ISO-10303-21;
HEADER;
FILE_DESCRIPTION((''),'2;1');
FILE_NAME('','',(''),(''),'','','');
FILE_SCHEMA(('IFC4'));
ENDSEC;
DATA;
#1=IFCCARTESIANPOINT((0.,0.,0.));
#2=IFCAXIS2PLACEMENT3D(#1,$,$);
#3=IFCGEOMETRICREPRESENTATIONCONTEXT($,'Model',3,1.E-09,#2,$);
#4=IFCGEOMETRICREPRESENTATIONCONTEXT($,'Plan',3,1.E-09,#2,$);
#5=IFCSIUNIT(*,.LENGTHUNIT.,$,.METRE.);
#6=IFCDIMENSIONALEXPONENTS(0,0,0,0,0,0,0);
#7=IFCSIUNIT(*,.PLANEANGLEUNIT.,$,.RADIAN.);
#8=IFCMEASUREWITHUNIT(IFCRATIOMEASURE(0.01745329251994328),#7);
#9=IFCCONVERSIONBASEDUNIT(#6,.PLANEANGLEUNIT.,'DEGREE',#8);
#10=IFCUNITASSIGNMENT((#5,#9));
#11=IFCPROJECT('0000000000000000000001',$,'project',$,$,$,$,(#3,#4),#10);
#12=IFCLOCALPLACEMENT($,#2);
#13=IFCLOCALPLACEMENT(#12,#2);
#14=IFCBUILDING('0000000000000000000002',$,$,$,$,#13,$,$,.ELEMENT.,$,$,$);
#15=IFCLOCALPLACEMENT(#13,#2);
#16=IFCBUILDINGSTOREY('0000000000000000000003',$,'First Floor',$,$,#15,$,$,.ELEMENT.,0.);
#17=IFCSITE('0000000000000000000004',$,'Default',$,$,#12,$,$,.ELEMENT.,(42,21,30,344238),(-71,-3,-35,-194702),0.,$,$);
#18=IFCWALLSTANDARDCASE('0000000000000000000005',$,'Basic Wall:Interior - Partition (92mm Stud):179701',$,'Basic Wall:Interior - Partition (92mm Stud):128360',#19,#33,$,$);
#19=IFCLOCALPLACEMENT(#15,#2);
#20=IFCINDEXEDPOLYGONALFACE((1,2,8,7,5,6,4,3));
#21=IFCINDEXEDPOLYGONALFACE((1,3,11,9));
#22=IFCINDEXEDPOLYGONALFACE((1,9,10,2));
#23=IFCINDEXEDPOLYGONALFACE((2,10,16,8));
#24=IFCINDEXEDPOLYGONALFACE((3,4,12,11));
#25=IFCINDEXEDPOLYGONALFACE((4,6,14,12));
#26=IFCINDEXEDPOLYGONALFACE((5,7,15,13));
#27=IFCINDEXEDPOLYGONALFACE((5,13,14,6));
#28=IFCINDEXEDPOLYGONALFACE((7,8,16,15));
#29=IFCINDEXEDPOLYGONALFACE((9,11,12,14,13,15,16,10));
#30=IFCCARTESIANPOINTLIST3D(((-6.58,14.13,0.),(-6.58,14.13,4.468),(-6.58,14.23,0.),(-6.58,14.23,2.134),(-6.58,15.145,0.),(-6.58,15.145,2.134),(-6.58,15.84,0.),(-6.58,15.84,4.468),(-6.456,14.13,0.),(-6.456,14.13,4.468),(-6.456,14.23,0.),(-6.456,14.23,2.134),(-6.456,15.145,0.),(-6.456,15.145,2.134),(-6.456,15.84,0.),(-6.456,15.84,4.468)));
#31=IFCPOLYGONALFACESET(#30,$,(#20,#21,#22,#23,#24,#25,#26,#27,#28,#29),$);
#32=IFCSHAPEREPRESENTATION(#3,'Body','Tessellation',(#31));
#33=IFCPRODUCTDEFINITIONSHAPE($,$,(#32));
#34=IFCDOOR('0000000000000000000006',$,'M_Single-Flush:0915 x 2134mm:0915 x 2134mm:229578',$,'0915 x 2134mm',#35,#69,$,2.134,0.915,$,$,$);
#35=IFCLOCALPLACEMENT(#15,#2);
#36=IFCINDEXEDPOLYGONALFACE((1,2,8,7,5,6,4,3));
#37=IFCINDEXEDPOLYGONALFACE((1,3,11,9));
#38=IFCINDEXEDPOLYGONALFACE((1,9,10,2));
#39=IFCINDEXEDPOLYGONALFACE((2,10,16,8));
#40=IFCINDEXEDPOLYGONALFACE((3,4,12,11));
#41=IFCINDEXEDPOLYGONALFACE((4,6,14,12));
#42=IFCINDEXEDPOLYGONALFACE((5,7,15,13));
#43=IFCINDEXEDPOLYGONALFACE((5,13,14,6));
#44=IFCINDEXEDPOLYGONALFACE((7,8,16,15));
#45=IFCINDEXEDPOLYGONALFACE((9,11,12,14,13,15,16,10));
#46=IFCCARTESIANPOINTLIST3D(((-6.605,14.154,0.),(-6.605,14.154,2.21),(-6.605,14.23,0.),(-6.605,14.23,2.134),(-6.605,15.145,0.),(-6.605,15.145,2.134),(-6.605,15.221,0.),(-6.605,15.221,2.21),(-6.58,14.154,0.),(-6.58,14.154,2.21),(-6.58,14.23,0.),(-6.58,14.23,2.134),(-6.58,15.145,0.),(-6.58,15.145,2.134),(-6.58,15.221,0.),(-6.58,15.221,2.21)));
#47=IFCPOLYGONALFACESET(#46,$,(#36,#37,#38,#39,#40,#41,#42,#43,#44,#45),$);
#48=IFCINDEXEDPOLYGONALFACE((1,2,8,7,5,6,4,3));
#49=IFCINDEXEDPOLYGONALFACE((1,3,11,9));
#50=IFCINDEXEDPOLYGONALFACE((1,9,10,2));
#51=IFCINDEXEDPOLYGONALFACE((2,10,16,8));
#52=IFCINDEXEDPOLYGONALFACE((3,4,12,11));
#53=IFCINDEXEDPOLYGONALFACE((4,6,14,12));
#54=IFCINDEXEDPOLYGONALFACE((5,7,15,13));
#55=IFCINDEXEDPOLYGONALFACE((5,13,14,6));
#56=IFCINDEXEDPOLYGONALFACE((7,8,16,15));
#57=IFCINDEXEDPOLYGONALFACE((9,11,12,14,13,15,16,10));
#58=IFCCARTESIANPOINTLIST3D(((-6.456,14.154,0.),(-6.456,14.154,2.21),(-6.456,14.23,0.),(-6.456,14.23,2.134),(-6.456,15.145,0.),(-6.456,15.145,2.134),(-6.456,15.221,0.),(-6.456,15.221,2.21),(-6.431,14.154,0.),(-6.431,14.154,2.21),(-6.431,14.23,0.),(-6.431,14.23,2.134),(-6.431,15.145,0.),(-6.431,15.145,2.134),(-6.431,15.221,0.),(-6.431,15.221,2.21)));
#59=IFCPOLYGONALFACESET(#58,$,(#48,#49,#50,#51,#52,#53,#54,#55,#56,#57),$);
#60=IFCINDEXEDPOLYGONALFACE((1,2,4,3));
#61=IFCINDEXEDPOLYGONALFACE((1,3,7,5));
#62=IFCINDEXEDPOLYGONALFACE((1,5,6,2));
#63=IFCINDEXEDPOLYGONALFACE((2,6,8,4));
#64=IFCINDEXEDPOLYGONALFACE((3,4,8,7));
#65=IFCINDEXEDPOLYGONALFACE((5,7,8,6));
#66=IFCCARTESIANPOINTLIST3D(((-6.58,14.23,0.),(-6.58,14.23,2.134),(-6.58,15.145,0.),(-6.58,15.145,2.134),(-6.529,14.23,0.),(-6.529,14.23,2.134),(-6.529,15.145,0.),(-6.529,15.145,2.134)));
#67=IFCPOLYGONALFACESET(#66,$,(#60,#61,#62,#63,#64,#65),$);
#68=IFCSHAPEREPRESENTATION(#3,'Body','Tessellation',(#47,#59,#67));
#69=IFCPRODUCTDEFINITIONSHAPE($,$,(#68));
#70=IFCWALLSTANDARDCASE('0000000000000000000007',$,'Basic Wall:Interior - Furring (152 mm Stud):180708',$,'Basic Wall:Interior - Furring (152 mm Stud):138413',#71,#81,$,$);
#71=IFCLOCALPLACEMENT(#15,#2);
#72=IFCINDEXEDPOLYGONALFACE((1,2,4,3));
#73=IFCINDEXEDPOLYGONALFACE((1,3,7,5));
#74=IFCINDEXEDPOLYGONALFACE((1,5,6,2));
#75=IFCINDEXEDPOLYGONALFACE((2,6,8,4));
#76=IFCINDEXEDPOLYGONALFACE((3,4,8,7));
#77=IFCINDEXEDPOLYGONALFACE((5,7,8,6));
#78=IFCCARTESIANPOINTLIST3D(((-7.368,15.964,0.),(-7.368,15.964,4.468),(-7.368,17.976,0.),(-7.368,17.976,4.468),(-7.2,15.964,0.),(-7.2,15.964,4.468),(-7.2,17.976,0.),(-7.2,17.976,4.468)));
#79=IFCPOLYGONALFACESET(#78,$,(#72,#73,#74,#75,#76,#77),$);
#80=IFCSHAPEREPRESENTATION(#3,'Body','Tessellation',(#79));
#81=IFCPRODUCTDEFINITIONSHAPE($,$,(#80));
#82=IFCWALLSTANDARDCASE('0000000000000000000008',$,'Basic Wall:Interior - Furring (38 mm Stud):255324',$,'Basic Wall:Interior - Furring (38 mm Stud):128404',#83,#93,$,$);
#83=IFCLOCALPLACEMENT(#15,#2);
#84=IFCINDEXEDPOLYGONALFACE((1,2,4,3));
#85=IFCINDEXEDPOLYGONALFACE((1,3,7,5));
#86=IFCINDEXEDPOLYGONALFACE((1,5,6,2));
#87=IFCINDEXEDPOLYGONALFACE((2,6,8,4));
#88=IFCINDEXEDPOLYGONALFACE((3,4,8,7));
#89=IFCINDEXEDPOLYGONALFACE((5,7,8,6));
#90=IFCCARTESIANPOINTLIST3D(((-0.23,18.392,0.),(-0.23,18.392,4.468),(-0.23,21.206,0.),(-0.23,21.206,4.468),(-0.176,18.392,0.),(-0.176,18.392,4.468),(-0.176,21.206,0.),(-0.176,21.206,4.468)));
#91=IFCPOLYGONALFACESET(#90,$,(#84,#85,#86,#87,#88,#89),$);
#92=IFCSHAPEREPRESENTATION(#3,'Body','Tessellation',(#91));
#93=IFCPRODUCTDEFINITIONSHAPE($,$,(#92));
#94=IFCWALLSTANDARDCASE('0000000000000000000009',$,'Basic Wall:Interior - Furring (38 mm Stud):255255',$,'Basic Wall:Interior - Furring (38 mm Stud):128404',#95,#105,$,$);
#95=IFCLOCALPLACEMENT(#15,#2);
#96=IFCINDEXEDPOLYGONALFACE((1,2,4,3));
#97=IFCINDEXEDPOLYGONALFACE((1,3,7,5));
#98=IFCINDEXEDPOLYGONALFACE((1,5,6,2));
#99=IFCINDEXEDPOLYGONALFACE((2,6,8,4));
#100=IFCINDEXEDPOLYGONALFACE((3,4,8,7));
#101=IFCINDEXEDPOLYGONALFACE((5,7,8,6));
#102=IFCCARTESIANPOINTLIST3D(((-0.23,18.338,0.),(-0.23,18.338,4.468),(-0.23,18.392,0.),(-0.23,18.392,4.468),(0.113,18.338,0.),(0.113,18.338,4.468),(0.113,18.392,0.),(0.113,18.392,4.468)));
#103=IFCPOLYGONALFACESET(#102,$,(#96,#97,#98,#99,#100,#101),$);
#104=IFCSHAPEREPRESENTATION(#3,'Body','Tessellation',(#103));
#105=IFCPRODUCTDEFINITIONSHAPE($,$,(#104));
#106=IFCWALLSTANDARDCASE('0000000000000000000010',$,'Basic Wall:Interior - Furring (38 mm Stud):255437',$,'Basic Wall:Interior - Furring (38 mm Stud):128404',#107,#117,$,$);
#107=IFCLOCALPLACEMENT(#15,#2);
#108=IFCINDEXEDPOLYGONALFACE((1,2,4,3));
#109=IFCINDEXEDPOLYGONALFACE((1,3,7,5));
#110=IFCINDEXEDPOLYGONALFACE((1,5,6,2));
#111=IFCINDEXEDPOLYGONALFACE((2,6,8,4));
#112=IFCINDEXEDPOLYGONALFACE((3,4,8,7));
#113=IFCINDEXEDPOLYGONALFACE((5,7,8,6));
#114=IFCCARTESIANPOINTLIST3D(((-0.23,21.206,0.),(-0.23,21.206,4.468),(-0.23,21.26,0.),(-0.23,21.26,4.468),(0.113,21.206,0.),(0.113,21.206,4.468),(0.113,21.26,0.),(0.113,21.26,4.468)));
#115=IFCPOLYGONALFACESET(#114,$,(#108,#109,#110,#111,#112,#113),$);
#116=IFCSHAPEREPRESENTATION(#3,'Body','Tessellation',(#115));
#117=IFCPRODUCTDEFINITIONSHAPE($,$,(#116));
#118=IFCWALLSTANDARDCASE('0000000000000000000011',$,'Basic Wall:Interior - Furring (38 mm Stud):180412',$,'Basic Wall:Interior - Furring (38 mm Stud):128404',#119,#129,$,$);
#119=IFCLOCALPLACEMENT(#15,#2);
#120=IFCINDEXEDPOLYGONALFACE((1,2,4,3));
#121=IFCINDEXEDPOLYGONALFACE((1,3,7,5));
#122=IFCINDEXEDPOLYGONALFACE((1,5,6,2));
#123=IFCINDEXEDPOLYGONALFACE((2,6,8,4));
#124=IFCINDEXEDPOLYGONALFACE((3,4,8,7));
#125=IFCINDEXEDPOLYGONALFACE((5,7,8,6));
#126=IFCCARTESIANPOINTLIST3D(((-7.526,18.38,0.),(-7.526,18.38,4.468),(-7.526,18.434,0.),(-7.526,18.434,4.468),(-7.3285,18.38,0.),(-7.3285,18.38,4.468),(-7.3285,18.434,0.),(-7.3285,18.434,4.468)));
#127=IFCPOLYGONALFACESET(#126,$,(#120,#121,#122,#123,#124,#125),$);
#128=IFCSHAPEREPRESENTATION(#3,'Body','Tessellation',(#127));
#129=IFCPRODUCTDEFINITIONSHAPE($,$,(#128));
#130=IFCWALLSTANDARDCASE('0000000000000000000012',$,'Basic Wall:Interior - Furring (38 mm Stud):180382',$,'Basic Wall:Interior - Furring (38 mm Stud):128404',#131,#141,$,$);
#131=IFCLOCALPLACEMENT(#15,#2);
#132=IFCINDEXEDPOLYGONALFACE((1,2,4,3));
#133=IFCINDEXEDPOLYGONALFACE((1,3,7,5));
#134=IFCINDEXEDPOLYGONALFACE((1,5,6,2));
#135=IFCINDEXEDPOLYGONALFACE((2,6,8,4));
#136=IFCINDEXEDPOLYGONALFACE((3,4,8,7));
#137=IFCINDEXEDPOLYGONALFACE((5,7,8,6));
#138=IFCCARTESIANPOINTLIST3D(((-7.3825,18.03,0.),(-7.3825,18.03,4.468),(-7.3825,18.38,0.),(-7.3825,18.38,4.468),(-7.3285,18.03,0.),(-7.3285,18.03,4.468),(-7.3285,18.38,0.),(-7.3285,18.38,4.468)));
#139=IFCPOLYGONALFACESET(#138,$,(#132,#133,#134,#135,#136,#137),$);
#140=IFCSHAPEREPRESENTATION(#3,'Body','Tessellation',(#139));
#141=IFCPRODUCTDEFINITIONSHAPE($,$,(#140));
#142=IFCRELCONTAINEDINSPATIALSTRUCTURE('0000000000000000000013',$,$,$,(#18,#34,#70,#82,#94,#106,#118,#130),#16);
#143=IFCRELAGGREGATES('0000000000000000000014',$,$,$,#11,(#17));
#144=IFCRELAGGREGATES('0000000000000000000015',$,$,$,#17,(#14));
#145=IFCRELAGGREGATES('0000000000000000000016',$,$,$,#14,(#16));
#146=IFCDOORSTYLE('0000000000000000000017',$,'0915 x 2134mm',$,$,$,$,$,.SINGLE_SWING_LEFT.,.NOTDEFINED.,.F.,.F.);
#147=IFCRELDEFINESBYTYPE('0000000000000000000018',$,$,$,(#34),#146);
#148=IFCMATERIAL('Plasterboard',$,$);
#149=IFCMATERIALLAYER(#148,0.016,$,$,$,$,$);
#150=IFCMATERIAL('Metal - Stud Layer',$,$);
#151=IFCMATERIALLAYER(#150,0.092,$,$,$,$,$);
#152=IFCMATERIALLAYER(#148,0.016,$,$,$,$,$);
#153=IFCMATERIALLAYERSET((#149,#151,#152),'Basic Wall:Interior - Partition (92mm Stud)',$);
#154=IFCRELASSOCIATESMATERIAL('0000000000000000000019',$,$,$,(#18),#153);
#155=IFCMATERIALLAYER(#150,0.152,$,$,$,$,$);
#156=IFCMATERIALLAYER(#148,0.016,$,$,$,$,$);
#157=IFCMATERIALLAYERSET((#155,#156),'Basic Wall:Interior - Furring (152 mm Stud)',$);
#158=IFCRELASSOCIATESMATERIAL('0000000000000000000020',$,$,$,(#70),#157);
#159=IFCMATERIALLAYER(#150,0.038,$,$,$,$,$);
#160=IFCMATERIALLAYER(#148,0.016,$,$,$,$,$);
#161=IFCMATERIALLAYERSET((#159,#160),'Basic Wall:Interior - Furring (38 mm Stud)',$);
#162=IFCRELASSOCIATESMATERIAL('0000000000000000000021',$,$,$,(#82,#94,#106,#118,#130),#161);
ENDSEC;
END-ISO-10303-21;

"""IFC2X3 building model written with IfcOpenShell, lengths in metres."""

from ifc_helpers import new_model, entity, si_unit, converted_unit, frame, frame_2d, origin, origin_2d_with_axis, place, context, project, spatial, polyline, rectangle, outline, extrude, source, transform, mapped, material, layer, layer_set, layer_usage, type_object, type_shapes, element, fill, save


model = new_model("IFC2X3")

# Units and contexts
model_context = context("Model", 3, precision=1e-09, world=origin())
plan_context = context("Plan", 3, precision=1e-09, world=origin())
ifc_project = project(units=[si_unit("LENGTHUNIT", "METRE"), converted_unit("PLANEANGLEUNIT", "DEGREE", entity("IfcRatioMeasure", 0.01745329251994328), si_unit("PLANEANGLEUNIT", "RADIAN"), dimensions=[0, 0, 0, 0, 0, 0, 0])], contexts=[model_context, plan_context])

# Site, building, storey
site_placement = place(None, origin())
site = spatial("IfcSite", under=ifc_project, at=site_placement, Name="Default", CompositionType="ELEMENT", RefLatitude=(42, 21, 30, 344238), RefLongitude=(-71, -3, -35, -194702), RefElevation=0.0)
building_placement = place(site_placement, origin())
building = spatial("IfcBuilding", under=site, at=building_placement, CompositionType="ELEMENT")
storey_placement = place(building_placement, origin())
storey = spatial("IfcBuildingStorey", under=building, at=storey_placement, Name="First Floor", CompositionType="ELEMENT", Elevation=0.0)

# Shared definitions
ifc_material_1 = material(Name="Plasterboard")
ifc_layer_1 = layer(ifc_material_1, 0.016)
ifc_material_2 = material(Name="Metal - Stud Layer")
ifc_layer_2 = layer(ifc_material_2, 0.092)
ifc_layer_3 = layer(ifc_material_1, 0.016)
ifc_layer_set_1 = layer_set([ifc_layer_1, ifc_layer_2, ifc_layer_3], Name="Basic Wall:Interior - Partition (92mm Stud)")
ifc_layer_usage_1 = layer_usage(ifc_layer_set_1, "AXIS2", "NEGATIVE", 0.062)

# Shared definitions
door_style_1 = type_object("IfcDoorStyle", Name="0915 x 2134mm", ConstructionType="NOTDEFINED", OperationType="SINGLE_SWING_LEFT", ParameterTakesPrecedence=False, Sizeable=False)
shared_shape_1 = source(origin(), model_context, "Body", "SweptSolid", [
    extrude(outline(polyline([(-0.5335, -1.124), (0.5335, -1.124), (0.5335, 1.086), (0.4575, 1.086), (0.4575, -1.048), (-0.4575, -1.048), (-0.4575, 1.086), (-0.5335, 1.086), (-0.5335, -1.124)])), frame((0.4575, 0.149, 1.086), z_axis=(0.0, -1.0, 0.0), x_axis=(-1.0, 0.0, 0.0)), (0.0, 0.0, 1.0), 0.025),
    extrude(outline(polyline([(-1.124, -0.5335), (1.086, -0.5335), (1.086, -0.4575), (-1.048, -0.4575), (-1.048, 0.4575), (1.086, 0.4575), (1.086, 0.5335), (-1.124, 0.5335), (-1.124, -0.5335)])), frame((0.4575, 0.0, 1.086), z_axis=(0.0, -1.0, 0.0), x_axis=(0.0, 0.0, -1.0)), (0.0, 0.0, 1.0), 0.025),
    extrude(rectangle(XDim=0.915, YDim=0.051, at=origin_2d_with_axis()), frame((0.4575, 0.0985, 0.0)), (0.0, 0.0, 1.0), 2.134),
])
type_shapes(door_style_1, [shared_shape_1])

# Wall, opening, door
wall_1_placement = place(storey_placement, frame((-6.518, 14.13, 0.0), z_axis=(0.0, 0.0, 1.0), x_axis=(0.0, 1.0, 0.0)))
wall_1 = element("IfcWallStandardCase", 1, at=wall_1_placement, inside=storey, material=ifc_layer_usage_1, Name="Basic Wall:Interior - Partition (92mm Stud):179701", ObjectType="Basic Wall:Interior - Partition (92mm Stud):128360", context=model_context, shape_type="SweptSolid", body=[
    extrude(rectangle(XDim=1.71, YDim=0.124, at=frame_2d((0.855, 0.0), x_axis=(-1.0, 0.0))), origin(), (0.0, 0.0, 1.0), 4.468),
])
opening_1_placement = place(wall_1_placement, frame((0.1, -0.062, 0.0)))
opening_1 = element("IfcOpeningElement", 2, at=opening_1_placement, cuts=wall_1, ObjectType="Opening", context=model_context, shape_type="SweptSolid", body=[
    extrude(rectangle(XDim=0.915, YDim=2.134, at=frame_2d((1.067, 0.4575), x_axis=(0.0, -1.0))), frame((0.0, 0.0, 0.0), z_axis=(0.0, 1.0, 0.0), x_axis=(0.0, 0.0, 1.0)), (0.0, 0.0, 1.0), 0.124),
])
door_1_placement = place(opening_1_placement, origin())
door_1 = element("IfcDoor", 3, at=door_1_placement, inside=storey, type_object=door_style_1, Name="M_Single-Flush:0915 x 2134mm:0915 x 2134mm:229578", ObjectType="0915 x 2134mm", OverallHeight=2.134, OverallWidth=0.915, context=model_context, shape_type="MappedRepresentation", body=[
    mapped(shared_shape_1, transform((0.0, 0.0, 0.0), scale=1.0)),
])
fill(opening_1, door_1)

# Walls
ifc_layer_4 = layer(ifc_material_2, 0.152)
ifc_layer_5 = layer(ifc_material_1, 0.016)
ifc_layer_set_2 = layer_set([ifc_layer_4, ifc_layer_5], Name="Basic Wall:Interior - Furring (152 mm Stud)")
ifc_layer_usage_2 = layer_usage(ifc_layer_set_2, "AXIS2", "POSITIVE", -0.084)
wall_2_placement = place(storey_placement, frame((-7.284, 17.976, 0.0), z_axis=(0.0, 0.0, 1.0), x_axis=(0.0, -1.0, 0.0)))
element("IfcWallStandardCase", 4, at=wall_2_placement, inside=storey, material=ifc_layer_usage_2, Name="Basic Wall:Interior - Furring (152 mm Stud):180708", ObjectType="Basic Wall:Interior - Furring (152 mm Stud):138413", context=model_context, shape_type="SweptSolid", body=[
    extrude(rectangle(XDim=2.012, YDim=0.168, at=frame_2d((1.006, 0.0), x_axis=(-1.0, 0.0))), origin(), (0.0, 0.0, 1.0), 4.468),
])
ifc_layer_6 = layer(ifc_material_2, 0.038)
ifc_layer_7 = layer(ifc_material_1, 0.016)
ifc_layer_set_3 = layer_set([ifc_layer_6, ifc_layer_7], Name="Basic Wall:Interior - Furring (38 mm Stud)")
ifc_layer_usage_3 = layer_usage(ifc_layer_set_3, "AXIS2", "POSITIVE", -0.027)
wall_3_placement = place(storey_placement, frame((-0.203, 18.392, 0.0), z_axis=(0.0, 0.0, 1.0), x_axis=(0.0, 1.0, 0.0)))
element("IfcWallStandardCase", 5, at=wall_3_placement, inside=storey, material=ifc_layer_usage_3, Name="Basic Wall:Interior - Furring (38 mm Stud):255324", ObjectType="Basic Wall:Interior - Furring (38 mm Stud):128404", context=model_context, shape_type="SweptSolid", body=[
    extrude(rectangle(XDim=2.814, YDim=0.054, at=frame_2d((1.407, 0.0), x_axis=(-1.0, 0.0))), origin(), (0.0, 0.0, 1.0), 4.468),
])
wall_4_placement = place(storey_placement, frame((0.113, 18.365, 0.0), z_axis=(0.0, 0.0, 1.0), x_axis=(-1.0, 0.0, 0.0)))
element("IfcWallStandardCase", 6, at=wall_4_placement, inside=storey, material=ifc_layer_usage_3, Name="Basic Wall:Interior - Furring (38 mm Stud):255255", ObjectType="Basic Wall:Interior - Furring (38 mm Stud):128404", context=model_context, shape_type="SweptSolid", body=[
    extrude(rectangle(XDim=0.343, YDim=0.054, at=frame_2d((0.1715, 0.0), x_axis=(-1.0, 0.0))), origin(), (0.0, 0.0, 1.0), 4.468),
])
wall_5_placement = place(storey_placement, frame((-0.23, 21.233, 0.0)))
element("IfcWallStandardCase", 7, at=wall_5_placement, inside=storey, material=ifc_layer_usage_3, Name="Basic Wall:Interior - Furring (38 mm Stud):255437", ObjectType="Basic Wall:Interior - Furring (38 mm Stud):128404", context=model_context, shape_type="SweptSolid", body=[
    extrude(rectangle(XDim=0.343, YDim=0.054, at=frame_2d((0.1715, 0.0), x_axis=(-1.0, 0.0))), origin(), (0.0, 0.0, 1.0), 4.468),
])
wall_6_placement = place(storey_placement, frame((-7.3285, 18.407, 0.0), z_axis=(0.0, 0.0, 1.0), x_axis=(-1.0, 0.0, 0.0)))
element("IfcWallStandardCase", 8, at=wall_6_placement, inside=storey, material=ifc_layer_usage_3, Name="Basic Wall:Interior - Furring (38 mm Stud):180412", ObjectType="Basic Wall:Interior - Furring (38 mm Stud):128404", context=model_context, shape_type="SweptSolid", body=[
    extrude(rectangle(XDim=0.1975, YDim=0.054, at=frame_2d((0.0987, 0.0), x_axis=(-1.0, 0.0))), origin(), (0.0, 0.0, 1.0), 4.468),
])
wall_7_placement = place(storey_placement, frame((-7.3555, 18.03, 0.0), z_axis=(0.0, 0.0, 1.0), x_axis=(0.0, 1.0, 0.0)))
element("IfcWallStandardCase", 9, at=wall_7_placement, inside=storey, material=ifc_layer_usage_3, Name="Basic Wall:Interior - Furring (38 mm Stud):180382", ObjectType="Basic Wall:Interior - Furring (38 mm Stud):128404", context=model_context, shape_type="SweptSolid", body=[
    extrude(rectangle(XDim=0.35, YDim=0.054, at=frame_2d((0.175, 0.0), x_axis=(-1.0, 0.0))), origin(), (0.0, 0.0, 1.0), 4.468),
])

save(model, "model.ifc")
